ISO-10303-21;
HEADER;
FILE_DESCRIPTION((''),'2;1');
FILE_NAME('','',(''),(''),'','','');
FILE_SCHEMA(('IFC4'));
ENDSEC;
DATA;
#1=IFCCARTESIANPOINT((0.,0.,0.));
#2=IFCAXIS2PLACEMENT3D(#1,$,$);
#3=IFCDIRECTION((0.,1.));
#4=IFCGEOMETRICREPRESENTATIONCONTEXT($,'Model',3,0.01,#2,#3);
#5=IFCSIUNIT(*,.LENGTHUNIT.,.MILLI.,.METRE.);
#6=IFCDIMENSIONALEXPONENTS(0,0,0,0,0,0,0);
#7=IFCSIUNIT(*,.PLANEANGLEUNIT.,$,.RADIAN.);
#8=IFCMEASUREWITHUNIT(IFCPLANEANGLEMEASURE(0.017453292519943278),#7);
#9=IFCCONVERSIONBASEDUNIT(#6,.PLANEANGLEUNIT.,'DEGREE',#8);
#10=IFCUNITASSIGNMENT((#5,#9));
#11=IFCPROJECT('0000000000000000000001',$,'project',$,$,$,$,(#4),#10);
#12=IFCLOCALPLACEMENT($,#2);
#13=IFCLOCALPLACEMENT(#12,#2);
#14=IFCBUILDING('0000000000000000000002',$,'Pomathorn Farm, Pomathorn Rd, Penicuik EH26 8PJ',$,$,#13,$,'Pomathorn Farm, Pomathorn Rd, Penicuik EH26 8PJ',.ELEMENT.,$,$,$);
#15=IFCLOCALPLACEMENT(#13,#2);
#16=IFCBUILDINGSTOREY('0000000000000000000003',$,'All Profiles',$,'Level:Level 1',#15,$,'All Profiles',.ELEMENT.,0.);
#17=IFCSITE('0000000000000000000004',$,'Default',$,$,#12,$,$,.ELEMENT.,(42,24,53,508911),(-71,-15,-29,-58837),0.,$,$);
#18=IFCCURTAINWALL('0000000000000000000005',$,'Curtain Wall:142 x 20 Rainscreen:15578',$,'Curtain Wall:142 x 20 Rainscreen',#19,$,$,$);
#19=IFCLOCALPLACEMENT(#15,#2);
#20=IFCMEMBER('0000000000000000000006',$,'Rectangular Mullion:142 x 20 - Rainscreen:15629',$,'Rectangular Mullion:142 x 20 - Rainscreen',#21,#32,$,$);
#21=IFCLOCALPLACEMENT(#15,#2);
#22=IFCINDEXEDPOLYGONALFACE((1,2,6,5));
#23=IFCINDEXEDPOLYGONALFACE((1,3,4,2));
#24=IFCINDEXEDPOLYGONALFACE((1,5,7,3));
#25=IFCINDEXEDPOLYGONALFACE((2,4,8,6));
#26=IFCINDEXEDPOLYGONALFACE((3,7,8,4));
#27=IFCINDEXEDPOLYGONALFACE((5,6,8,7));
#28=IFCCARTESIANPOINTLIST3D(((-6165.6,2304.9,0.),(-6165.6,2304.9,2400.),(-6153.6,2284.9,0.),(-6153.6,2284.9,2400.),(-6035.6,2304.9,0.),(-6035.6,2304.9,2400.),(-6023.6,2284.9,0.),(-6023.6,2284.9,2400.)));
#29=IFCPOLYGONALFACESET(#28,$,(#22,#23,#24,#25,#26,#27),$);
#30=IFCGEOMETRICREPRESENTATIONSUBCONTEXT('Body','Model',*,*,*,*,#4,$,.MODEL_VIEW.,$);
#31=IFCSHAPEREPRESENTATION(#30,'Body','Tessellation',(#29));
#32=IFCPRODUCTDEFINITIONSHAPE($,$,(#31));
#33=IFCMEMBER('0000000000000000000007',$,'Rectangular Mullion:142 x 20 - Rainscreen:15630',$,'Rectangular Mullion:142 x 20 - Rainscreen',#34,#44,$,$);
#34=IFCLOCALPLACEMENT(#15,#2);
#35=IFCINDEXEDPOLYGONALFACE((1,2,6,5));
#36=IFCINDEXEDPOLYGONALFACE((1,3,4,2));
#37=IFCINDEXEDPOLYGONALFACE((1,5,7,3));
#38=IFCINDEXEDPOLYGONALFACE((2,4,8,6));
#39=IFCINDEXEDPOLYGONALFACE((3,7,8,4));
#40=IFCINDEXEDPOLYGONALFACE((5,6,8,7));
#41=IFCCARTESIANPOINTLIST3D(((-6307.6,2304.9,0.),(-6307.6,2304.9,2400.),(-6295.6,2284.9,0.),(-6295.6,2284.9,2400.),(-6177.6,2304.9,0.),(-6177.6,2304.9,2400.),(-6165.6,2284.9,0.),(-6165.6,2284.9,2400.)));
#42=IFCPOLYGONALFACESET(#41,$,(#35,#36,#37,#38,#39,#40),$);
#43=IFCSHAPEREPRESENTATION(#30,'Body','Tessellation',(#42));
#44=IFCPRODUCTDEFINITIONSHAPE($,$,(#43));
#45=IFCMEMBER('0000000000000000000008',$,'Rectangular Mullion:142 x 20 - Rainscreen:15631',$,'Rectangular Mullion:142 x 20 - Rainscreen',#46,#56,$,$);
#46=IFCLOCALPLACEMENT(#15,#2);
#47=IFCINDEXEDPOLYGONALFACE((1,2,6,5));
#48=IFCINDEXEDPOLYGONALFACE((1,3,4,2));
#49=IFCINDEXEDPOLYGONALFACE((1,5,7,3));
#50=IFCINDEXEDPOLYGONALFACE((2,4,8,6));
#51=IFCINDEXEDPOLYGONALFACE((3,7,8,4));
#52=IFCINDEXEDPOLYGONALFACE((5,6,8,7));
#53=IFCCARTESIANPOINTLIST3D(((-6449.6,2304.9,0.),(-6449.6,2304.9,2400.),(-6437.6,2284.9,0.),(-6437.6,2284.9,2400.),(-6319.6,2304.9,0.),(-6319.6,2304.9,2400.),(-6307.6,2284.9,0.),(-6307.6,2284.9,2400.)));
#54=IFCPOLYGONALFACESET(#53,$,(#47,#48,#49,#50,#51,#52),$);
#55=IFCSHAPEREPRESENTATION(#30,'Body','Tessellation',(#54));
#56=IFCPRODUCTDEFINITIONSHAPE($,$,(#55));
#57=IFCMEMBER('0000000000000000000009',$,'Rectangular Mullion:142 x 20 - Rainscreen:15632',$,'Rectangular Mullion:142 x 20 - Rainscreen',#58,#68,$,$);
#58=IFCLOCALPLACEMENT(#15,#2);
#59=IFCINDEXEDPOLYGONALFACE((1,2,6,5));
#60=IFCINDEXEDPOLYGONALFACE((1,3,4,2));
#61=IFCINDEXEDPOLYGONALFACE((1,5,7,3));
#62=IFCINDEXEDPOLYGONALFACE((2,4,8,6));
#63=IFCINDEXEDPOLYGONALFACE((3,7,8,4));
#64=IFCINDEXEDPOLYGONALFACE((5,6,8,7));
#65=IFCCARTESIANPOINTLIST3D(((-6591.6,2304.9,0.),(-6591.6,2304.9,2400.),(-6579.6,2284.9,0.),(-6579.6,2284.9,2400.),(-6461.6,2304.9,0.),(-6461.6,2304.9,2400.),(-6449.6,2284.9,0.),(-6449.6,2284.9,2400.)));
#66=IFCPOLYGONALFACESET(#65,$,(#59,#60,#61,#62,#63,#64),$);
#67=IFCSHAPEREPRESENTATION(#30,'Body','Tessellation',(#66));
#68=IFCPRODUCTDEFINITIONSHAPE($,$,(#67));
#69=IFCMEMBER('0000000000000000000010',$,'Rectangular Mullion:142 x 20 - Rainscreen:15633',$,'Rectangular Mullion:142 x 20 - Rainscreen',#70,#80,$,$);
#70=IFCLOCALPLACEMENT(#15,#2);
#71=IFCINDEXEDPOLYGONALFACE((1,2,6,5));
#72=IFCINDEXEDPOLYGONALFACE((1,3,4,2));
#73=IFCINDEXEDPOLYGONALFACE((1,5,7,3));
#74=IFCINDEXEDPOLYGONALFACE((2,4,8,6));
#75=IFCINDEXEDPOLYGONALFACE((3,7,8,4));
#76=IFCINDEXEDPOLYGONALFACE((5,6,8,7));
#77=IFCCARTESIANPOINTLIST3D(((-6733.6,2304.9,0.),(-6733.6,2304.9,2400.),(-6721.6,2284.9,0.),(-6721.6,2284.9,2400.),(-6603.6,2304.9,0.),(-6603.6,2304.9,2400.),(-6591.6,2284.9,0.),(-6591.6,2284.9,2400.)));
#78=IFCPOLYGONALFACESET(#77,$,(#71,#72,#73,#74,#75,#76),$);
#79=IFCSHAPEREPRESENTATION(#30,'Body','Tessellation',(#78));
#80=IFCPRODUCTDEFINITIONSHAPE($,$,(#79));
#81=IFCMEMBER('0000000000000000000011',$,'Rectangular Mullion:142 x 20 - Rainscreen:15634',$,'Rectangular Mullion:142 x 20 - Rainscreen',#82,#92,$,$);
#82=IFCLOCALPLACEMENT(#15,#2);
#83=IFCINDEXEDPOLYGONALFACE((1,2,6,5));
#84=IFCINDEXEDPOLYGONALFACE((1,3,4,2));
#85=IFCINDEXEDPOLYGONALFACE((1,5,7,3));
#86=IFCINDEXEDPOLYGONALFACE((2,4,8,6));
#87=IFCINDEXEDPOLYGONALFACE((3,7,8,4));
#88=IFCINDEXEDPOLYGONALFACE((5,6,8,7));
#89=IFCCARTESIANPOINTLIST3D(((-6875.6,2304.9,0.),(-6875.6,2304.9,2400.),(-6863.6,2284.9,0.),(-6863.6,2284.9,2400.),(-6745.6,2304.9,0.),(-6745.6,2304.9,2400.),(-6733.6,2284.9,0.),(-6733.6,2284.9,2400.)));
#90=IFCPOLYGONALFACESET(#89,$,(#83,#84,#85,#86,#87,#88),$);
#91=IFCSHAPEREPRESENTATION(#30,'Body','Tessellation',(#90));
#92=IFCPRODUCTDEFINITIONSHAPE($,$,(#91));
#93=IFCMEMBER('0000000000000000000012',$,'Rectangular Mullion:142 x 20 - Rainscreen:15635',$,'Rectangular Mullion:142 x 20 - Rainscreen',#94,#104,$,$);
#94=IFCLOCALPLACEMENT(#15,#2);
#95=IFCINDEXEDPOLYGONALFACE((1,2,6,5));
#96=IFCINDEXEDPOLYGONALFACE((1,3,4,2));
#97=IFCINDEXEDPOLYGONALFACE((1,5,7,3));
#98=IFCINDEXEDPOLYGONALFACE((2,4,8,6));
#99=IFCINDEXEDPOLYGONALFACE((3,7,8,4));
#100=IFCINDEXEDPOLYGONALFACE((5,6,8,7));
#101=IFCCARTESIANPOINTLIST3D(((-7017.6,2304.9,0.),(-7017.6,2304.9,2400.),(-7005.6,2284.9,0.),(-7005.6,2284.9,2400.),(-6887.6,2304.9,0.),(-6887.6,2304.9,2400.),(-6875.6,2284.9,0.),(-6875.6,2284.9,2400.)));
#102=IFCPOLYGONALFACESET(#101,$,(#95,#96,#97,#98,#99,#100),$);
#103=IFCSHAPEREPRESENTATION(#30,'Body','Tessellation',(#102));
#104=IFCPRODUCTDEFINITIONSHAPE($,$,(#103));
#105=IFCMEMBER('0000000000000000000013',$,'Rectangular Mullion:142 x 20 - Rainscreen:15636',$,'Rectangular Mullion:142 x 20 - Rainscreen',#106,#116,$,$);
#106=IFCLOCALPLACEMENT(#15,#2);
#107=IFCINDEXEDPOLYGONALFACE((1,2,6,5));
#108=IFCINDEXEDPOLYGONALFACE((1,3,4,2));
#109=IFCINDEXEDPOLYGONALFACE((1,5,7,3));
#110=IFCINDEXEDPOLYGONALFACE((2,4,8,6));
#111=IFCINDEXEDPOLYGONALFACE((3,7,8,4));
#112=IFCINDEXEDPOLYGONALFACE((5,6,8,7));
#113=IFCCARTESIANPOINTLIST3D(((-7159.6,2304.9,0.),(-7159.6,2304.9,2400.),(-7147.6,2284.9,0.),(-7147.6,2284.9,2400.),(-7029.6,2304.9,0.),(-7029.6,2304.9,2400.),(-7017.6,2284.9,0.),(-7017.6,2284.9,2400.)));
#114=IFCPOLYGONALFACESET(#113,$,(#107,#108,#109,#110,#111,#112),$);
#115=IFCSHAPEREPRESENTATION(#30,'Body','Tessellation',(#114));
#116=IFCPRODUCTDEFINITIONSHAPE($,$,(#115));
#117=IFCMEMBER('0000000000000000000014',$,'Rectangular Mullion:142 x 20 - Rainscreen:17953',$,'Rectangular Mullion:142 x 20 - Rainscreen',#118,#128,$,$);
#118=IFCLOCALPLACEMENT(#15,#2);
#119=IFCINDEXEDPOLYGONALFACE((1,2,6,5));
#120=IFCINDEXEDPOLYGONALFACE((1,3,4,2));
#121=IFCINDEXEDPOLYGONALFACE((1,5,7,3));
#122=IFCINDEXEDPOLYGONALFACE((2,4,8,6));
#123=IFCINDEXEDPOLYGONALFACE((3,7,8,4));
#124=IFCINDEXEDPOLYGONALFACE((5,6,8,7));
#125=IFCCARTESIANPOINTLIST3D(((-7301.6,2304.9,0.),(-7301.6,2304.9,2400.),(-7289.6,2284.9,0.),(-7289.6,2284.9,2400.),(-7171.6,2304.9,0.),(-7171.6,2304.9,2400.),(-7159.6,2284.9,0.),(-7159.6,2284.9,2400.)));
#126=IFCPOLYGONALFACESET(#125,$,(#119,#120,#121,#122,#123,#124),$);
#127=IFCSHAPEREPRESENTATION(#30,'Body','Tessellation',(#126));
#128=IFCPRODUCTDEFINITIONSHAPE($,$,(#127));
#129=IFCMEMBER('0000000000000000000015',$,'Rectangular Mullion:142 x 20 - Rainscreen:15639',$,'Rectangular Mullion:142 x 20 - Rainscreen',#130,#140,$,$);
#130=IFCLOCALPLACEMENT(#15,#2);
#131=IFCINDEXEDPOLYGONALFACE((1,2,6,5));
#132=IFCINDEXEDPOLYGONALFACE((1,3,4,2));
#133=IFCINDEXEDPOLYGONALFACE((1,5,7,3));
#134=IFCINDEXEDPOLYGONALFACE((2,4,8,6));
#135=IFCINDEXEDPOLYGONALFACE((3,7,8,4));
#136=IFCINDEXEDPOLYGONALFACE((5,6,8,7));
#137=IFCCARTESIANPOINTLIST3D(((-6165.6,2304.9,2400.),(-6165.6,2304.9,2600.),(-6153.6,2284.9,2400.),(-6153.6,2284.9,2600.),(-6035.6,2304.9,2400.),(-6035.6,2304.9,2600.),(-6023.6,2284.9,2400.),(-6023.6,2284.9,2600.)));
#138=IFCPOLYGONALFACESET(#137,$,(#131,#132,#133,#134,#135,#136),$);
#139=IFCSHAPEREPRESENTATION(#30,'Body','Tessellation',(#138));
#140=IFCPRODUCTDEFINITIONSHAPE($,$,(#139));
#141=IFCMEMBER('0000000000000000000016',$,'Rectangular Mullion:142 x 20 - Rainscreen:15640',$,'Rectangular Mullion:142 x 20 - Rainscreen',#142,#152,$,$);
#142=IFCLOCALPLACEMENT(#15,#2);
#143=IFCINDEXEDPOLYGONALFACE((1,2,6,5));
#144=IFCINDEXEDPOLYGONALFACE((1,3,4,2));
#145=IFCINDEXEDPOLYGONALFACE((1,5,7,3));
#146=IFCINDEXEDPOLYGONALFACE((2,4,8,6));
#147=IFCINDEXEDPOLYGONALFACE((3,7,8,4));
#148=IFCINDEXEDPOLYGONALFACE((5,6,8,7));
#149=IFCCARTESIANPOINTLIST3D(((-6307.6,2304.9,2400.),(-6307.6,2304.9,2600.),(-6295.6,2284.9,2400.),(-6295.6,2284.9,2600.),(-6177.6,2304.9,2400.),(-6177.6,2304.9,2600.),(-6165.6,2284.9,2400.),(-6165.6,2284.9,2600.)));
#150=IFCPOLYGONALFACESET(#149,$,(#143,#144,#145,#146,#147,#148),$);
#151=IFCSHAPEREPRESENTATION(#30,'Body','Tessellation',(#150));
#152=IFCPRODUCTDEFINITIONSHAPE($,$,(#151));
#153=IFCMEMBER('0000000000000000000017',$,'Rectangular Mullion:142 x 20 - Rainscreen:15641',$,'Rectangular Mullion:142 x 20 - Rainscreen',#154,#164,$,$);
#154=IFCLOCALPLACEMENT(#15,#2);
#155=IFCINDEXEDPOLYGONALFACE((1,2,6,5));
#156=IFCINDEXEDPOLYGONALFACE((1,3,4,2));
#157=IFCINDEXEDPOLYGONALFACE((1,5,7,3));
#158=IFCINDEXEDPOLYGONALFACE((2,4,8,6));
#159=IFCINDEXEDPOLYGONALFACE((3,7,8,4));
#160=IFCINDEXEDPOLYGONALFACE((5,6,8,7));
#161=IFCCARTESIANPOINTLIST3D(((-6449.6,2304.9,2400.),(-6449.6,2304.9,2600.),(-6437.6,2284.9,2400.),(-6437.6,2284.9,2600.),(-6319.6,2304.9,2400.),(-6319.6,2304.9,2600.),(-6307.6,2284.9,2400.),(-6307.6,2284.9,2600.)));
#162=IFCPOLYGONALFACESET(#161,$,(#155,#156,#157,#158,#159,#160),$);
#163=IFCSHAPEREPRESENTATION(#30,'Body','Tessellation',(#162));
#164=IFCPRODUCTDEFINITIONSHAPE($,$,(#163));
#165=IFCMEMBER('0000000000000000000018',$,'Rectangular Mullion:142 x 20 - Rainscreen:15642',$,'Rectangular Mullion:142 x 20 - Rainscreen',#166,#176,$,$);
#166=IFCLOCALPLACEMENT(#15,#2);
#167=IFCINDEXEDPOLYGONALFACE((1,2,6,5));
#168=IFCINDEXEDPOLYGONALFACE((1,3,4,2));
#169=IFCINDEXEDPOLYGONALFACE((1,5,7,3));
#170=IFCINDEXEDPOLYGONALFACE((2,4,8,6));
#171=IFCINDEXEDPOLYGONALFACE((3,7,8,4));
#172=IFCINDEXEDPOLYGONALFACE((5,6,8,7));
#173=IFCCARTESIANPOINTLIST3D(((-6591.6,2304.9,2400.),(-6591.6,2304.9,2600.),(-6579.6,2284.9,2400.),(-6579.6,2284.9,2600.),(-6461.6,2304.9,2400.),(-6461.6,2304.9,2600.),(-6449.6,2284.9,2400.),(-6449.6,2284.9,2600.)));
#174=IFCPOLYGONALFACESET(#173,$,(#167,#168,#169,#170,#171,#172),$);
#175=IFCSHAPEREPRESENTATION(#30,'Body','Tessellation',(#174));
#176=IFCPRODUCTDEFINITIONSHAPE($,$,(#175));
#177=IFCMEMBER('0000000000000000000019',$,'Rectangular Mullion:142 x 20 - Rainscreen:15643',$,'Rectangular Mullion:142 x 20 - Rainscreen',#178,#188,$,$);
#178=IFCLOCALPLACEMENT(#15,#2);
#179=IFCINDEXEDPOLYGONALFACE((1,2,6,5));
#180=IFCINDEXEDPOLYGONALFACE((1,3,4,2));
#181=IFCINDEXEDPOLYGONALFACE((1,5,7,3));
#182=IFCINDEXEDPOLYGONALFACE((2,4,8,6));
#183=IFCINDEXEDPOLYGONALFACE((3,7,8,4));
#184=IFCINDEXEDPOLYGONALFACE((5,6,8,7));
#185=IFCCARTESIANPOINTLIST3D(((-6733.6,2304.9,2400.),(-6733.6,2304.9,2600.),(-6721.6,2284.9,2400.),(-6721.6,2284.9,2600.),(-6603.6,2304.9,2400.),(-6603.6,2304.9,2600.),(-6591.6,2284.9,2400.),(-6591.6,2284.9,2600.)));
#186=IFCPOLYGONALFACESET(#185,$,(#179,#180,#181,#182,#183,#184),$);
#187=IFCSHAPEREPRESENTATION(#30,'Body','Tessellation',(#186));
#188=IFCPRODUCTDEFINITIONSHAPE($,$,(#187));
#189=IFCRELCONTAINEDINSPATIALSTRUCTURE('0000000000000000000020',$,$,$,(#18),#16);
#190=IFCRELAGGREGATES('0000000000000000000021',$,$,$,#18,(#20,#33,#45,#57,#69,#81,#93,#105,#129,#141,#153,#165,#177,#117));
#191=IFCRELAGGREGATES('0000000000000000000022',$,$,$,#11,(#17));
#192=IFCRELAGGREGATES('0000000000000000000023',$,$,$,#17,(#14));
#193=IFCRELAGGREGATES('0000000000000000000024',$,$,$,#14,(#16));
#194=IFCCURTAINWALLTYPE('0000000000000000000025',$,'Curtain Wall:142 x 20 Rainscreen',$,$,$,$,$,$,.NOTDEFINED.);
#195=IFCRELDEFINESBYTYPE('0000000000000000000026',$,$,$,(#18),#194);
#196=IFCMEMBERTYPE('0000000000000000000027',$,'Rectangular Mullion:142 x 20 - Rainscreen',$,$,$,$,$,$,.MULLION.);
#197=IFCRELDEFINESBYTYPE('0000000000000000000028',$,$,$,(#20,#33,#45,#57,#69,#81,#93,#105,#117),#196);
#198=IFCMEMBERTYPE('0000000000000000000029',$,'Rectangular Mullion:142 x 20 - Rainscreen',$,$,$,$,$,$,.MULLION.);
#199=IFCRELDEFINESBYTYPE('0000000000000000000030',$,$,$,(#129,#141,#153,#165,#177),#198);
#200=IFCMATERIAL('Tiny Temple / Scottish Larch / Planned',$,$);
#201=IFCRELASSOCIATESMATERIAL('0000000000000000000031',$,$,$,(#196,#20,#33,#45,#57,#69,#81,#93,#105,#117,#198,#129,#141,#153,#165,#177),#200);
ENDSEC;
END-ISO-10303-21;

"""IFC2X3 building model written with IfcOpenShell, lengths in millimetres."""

from ifc_helpers import new_model, entity, si_unit, converted_unit, direction, frame, origin, place, context, subcontext, project, spatial, polyline, outline, extrude, source, transform, mapped, material, type_object, type_shapes, element, aggregate, save


model = new_model("IFC2X3")

# Units and contexts
model_context = context("Model", 3, precision=0.01, world=origin(), true_north=direction((0.0, 1.0)))
body_context = subcontext(model_context, "Body", "Model", "MODEL_VIEW")
ifc_project = project(units=[si_unit("LENGTHUNIT", "METRE", prefix="MILLI"), converted_unit("PLANEANGLEUNIT", "DEGREE", entity("IfcPlaneAngleMeasure", 0.017453292519943278), si_unit("PLANEANGLEUNIT", "RADIAN"), dimensions=[0, 0, 0, 0, 0, 0, 0])], contexts=[model_context])

# Site, building, storey
site_placement = place(None, origin())
site = spatial("IfcSite", under=ifc_project, at=site_placement, Name="Default", CompositionType="ELEMENT", RefLatitude=(42, 24, 53, 508911), RefLongitude=(-71, -15, -29, -58837), RefElevation=0.0)
building_placement = place(site_placement, origin())
building = spatial("IfcBuilding", under=site, at=building_placement, Name="Pomathorn Farm, Pomathorn Rd, Penicuik EH26 8PJ", LongName="Pomathorn Farm, Pomathorn Rd, Penicuik EH26 8PJ", CompositionType="ELEMENT")
storey_placement = place(building_placement, origin())
storey = spatial("IfcBuildingStorey", under=building, at=storey_placement, Name="All Profiles", ObjectType="Level:Level 1", LongName="All Profiles", CompositionType="ELEMENT", Elevation=0.0)

# Curtain wall, members
curtain_wall_type_1 = type_object("IfcCurtainWallType", Name="Curtain Wall:142 x 20 Rainscreen", PredefinedType="NOTDEFINED")
curtain_wall_1_placement = place(storey_placement, origin())
curtain_wall_1 = element("IfcCurtainWall", 1, at=curtain_wall_1_placement, inside=storey, type_object=curtain_wall_type_1, Name="Curtain Wall:142 x 20 Rainscreen:15578", ObjectType="Curtain Wall:142 x 20 Rainscreen")
ifc_material = material(Name="Tiny Temple / Scottish Larch / Planned")
member_type_1 = type_object("IfcMemberType", Name="Rectangular Mullion:142 x 20 - Rainscreen", PredefinedType="MULLION", material=ifc_material)
shared_shape_1 = source(origin(), body_context, "Body", "SweptSolid", [
    extrude(outline(polyline([(21.8, -55.7), (45.1, -55.7), (-21.8, 55.7), (-45.1, 55.7), (21.8, -55.7)])), frame((-71.0, -10.0, -2400.0), z_axis=(0.0, 0.0, 1.0), x_axis=(0.514496, 0.857493, 0.0)), (0.0, 0.0, 1.0), 2400.0),
])
type_shapes(member_type_1, [shared_shape_1])
member_1_placement = place(curtain_wall_1_placement, frame((-6023.6, 2284.9, 0.0), z_axis=(0.0, 0.0, -1.0), x_axis=(1.0, 0.0, 0.0)))
member_1 = element("IfcMember", 2, at=member_1_placement, type_object=member_type_1, material=ifc_material, Name="Rectangular Mullion:142 x 20 - Rainscreen:15629", ObjectType="Rectangular Mullion:142 x 20 - Rainscreen", context=body_context, shape_type="MappedRepresentation", body=[
    mapped(shared_shape_1, transform((0.0, 0.0, 0.0), scale=1.0)),
])
member_2_placement = place(curtain_wall_1_placement, frame((-6165.6, 2284.9, 0.0), z_axis=(0.0, 0.0, -1.0), x_axis=(1.0, 0.0, 0.0)))
member_2 = element("IfcMember", 3, at=member_2_placement, type_object=member_type_1, material=ifc_material, Name="Rectangular Mullion:142 x 20 - Rainscreen:15630", ObjectType="Rectangular Mullion:142 x 20 - Rainscreen", context=body_context, shape_type="MappedRepresentation", body=[
    mapped(shared_shape_1, transform((0.0, 0.0, 0.0), scale=1.0)),
])
member_3_placement = place(curtain_wall_1_placement, frame((-6307.6, 2284.9, 0.0), z_axis=(0.0, 0.0, -1.0), x_axis=(1.0, 0.0, 0.0)))
member_3 = element("IfcMember", 4, at=member_3_placement, type_object=member_type_1, material=ifc_material, Name="Rectangular Mullion:142 x 20 - Rainscreen:15631", ObjectType="Rectangular Mullion:142 x 20 - Rainscreen", context=body_context, shape_type="MappedRepresentation", body=[
    mapped(shared_shape_1, transform((0.0, 0.0, 0.0), scale=1.0)),
])
member_4_placement = place(curtain_wall_1_placement, frame((-6449.6, 2284.9, 0.0), z_axis=(0.0, 0.0, -1.0), x_axis=(1.0, 0.0, 0.0)))
member_4 = element("IfcMember", 5, at=member_4_placement, type_object=member_type_1, material=ifc_material, Name="Rectangular Mullion:142 x 20 - Rainscreen:15632", ObjectType="Rectangular Mullion:142 x 20 - Rainscreen", context=body_context, shape_type="MappedRepresentation", body=[
    mapped(shared_shape_1, transform((0.0, 0.0, 0.0), scale=1.0)),
])
member_5_placement = place(curtain_wall_1_placement, frame((-6591.6, 2284.9, 0.0), z_axis=(0.0, 0.0, -1.0), x_axis=(1.0, 0.0, 0.0)))
member_5 = element("IfcMember", 6, at=member_5_placement, type_object=member_type_1, material=ifc_material, Name="Rectangular Mullion:142 x 20 - Rainscreen:15633", ObjectType="Rectangular Mullion:142 x 20 - Rainscreen", context=body_context, shape_type="MappedRepresentation", body=[
    mapped(shared_shape_1, transform((0.0, 0.0, 0.0), scale=1.0)),
])
member_6_placement = place(curtain_wall_1_placement, frame((-6733.6, 2284.9, 0.0), z_axis=(0.0, 0.0, -1.0), x_axis=(1.0, 0.0, 0.0)))
member_6 = element("IfcMember", 7, at=member_6_placement, type_object=member_type_1, material=ifc_material, Name="Rectangular Mullion:142 x 20 - Rainscreen:15634", ObjectType="Rectangular Mullion:142 x 20 - Rainscreen", context=body_context, shape_type="MappedRepresentation", body=[
    mapped(shared_shape_1, transform((0.0, 0.0, 0.0), scale=1.0)),
])
member_7_placement = place(curtain_wall_1_placement, frame((-6875.6, 2284.9, 0.0), z_axis=(0.0, 0.0, -1.0), x_axis=(1.0, 0.0, 0.0)))
member_7 = element("IfcMember", 8, at=member_7_placement, type_object=member_type_1, material=ifc_material, Name="Rectangular Mullion:142 x 20 - Rainscreen:15635", ObjectType="Rectangular Mullion:142 x 20 - Rainscreen", context=body_context, shape_type="MappedRepresentation", body=[
    mapped(shared_shape_1, transform((0.0, 0.0, 0.0), scale=1.0)),
])
member_8_placement = place(curtain_wall_1_placement, frame((-7017.6, 2284.9, 0.0), z_axis=(0.0, 0.0, -1.0), x_axis=(1.0, 0.0, 0.0)))
member_8 = element("IfcMember", 9, at=member_8_placement, type_object=member_type_1, material=ifc_material, Name="Rectangular Mullion:142 x 20 - Rainscreen:15636", ObjectType="Rectangular Mullion:142 x 20 - Rainscreen", context=body_context, shape_type="MappedRepresentation", body=[
    mapped(shared_shape_1, transform((0.0, 0.0, 0.0), scale=1.0)),
])
member_9_placement = place(curtain_wall_1_placement, frame((-7159.6, 2284.9, 0.0), z_axis=(0.0, 0.0, -1.0), x_axis=(1.0, 0.0, 0.0)))
member_9 = element("IfcMember", 10, at=member_9_placement, type_object=member_type_1, material=ifc_material, Name="Rectangular Mullion:142 x 20 - Rainscreen:17953", ObjectType="Rectangular Mullion:142 x 20 - Rainscreen", context=body_context, shape_type="MappedRepresentation", body=[
    mapped(shared_shape_1, transform((0.0, 0.0, 0.0), scale=1.0)),
])
member_type_2 = type_object("IfcMemberType", Name="Rectangular Mullion:142 x 20 - Rainscreen", PredefinedType="MULLION", material=ifc_material)
shared_shape_2 = source(origin(), body_context, "Body", "SweptSolid", [
    extrude(outline(polyline([(21.8, -55.7), (45.1, -55.7), (-21.8, 55.7), (-45.1, 55.7), (21.8, -55.7)])), frame((-71.0, -10.0, -200.0), z_axis=(0.0, 0.0, 1.0), x_axis=(0.514496, 0.857493, 0.0)), (0.0, 0.0, 1.0), 200.0),
])
type_shapes(member_type_2, [shared_shape_2])
member_10_placement = place(curtain_wall_1_placement, frame((-6023.6, 2284.9, 2400.0), z_axis=(0.0, 0.0, -1.0), x_axis=(1.0, 0.0, 0.0)))
member_10 = element("IfcMember", 11, at=member_10_placement, type_object=member_type_2, material=ifc_material, Name="Rectangular Mullion:142 x 20 - Rainscreen:15639", ObjectType="Rectangular Mullion:142 x 20 - Rainscreen", context=body_context, shape_type="MappedRepresentation", body=[
    mapped(shared_shape_2, transform((0.0, 0.0, 0.0), scale=1.0)),
])
member_11_placement = place(curtain_wall_1_placement, frame((-6165.6, 2284.9, 2400.0), z_axis=(0.0, 0.0, -1.0), x_axis=(1.0, 0.0, 0.0)))
member_11 = element("IfcMember", 12, at=member_11_placement, type_object=member_type_2, material=ifc_material, Name="Rectangular Mullion:142 x 20 - Rainscreen:15640", ObjectType="Rectangular Mullion:142 x 20 - Rainscreen", context=body_context, shape_type="MappedRepresentation", body=[
    mapped(shared_shape_2, transform((0.0, 0.0, 0.0), scale=1.0)),
])
member_12_placement = place(curtain_wall_1_placement, frame((-6307.6, 2284.9, 2400.0), z_axis=(0.0, 0.0, -1.0), x_axis=(1.0, 0.0, 0.0)))
member_12 = element("IfcMember", 13, at=member_12_placement, type_object=member_type_2, material=ifc_material, Name="Rectangular Mullion:142 x 20 - Rainscreen:15641", ObjectType="Rectangular Mullion:142 x 20 - Rainscreen", context=body_context, shape_type="MappedRepresentation", body=[
    mapped(shared_shape_2, transform((0.0, 0.0, 0.0), scale=1.0)),
])
member_13_placement = place(curtain_wall_1_placement, frame((-6449.6, 2284.9, 2400.0), z_axis=(0.0, 0.0, -1.0), x_axis=(1.0, 0.0, 0.0)))
member_13 = element("IfcMember", 14, at=member_13_placement, type_object=member_type_2, material=ifc_material, Name="Rectangular Mullion:142 x 20 - Rainscreen:15642", ObjectType="Rectangular Mullion:142 x 20 - Rainscreen", context=body_context, shape_type="MappedRepresentation", body=[
    mapped(shared_shape_2, transform((0.0, 0.0, 0.0), scale=1.0)),
])
member_14_placement = place(curtain_wall_1_placement, frame((-6591.6, 2284.9, 2400.0), z_axis=(0.0, 0.0, -1.0), x_axis=(1.0, 0.0, 0.0)))
member_14 = element("IfcMember", 15, at=member_14_placement, type_object=member_type_2, material=ifc_material, Name="Rectangular Mullion:142 x 20 - Rainscreen:15643", ObjectType="Rectangular Mullion:142 x 20 - Rainscreen", context=body_context, shape_type="MappedRepresentation", body=[
    mapped(shared_shape_2, transform((0.0, 0.0, 0.0), scale=1.0)),
])
aggregate(curtain_wall_1, [member_1, member_2, member_3, member_4, member_5, member_6, member_7, member_8, member_10, member_11, member_12, member_13, member_14, member_9])

save(model, "model.ifc")
